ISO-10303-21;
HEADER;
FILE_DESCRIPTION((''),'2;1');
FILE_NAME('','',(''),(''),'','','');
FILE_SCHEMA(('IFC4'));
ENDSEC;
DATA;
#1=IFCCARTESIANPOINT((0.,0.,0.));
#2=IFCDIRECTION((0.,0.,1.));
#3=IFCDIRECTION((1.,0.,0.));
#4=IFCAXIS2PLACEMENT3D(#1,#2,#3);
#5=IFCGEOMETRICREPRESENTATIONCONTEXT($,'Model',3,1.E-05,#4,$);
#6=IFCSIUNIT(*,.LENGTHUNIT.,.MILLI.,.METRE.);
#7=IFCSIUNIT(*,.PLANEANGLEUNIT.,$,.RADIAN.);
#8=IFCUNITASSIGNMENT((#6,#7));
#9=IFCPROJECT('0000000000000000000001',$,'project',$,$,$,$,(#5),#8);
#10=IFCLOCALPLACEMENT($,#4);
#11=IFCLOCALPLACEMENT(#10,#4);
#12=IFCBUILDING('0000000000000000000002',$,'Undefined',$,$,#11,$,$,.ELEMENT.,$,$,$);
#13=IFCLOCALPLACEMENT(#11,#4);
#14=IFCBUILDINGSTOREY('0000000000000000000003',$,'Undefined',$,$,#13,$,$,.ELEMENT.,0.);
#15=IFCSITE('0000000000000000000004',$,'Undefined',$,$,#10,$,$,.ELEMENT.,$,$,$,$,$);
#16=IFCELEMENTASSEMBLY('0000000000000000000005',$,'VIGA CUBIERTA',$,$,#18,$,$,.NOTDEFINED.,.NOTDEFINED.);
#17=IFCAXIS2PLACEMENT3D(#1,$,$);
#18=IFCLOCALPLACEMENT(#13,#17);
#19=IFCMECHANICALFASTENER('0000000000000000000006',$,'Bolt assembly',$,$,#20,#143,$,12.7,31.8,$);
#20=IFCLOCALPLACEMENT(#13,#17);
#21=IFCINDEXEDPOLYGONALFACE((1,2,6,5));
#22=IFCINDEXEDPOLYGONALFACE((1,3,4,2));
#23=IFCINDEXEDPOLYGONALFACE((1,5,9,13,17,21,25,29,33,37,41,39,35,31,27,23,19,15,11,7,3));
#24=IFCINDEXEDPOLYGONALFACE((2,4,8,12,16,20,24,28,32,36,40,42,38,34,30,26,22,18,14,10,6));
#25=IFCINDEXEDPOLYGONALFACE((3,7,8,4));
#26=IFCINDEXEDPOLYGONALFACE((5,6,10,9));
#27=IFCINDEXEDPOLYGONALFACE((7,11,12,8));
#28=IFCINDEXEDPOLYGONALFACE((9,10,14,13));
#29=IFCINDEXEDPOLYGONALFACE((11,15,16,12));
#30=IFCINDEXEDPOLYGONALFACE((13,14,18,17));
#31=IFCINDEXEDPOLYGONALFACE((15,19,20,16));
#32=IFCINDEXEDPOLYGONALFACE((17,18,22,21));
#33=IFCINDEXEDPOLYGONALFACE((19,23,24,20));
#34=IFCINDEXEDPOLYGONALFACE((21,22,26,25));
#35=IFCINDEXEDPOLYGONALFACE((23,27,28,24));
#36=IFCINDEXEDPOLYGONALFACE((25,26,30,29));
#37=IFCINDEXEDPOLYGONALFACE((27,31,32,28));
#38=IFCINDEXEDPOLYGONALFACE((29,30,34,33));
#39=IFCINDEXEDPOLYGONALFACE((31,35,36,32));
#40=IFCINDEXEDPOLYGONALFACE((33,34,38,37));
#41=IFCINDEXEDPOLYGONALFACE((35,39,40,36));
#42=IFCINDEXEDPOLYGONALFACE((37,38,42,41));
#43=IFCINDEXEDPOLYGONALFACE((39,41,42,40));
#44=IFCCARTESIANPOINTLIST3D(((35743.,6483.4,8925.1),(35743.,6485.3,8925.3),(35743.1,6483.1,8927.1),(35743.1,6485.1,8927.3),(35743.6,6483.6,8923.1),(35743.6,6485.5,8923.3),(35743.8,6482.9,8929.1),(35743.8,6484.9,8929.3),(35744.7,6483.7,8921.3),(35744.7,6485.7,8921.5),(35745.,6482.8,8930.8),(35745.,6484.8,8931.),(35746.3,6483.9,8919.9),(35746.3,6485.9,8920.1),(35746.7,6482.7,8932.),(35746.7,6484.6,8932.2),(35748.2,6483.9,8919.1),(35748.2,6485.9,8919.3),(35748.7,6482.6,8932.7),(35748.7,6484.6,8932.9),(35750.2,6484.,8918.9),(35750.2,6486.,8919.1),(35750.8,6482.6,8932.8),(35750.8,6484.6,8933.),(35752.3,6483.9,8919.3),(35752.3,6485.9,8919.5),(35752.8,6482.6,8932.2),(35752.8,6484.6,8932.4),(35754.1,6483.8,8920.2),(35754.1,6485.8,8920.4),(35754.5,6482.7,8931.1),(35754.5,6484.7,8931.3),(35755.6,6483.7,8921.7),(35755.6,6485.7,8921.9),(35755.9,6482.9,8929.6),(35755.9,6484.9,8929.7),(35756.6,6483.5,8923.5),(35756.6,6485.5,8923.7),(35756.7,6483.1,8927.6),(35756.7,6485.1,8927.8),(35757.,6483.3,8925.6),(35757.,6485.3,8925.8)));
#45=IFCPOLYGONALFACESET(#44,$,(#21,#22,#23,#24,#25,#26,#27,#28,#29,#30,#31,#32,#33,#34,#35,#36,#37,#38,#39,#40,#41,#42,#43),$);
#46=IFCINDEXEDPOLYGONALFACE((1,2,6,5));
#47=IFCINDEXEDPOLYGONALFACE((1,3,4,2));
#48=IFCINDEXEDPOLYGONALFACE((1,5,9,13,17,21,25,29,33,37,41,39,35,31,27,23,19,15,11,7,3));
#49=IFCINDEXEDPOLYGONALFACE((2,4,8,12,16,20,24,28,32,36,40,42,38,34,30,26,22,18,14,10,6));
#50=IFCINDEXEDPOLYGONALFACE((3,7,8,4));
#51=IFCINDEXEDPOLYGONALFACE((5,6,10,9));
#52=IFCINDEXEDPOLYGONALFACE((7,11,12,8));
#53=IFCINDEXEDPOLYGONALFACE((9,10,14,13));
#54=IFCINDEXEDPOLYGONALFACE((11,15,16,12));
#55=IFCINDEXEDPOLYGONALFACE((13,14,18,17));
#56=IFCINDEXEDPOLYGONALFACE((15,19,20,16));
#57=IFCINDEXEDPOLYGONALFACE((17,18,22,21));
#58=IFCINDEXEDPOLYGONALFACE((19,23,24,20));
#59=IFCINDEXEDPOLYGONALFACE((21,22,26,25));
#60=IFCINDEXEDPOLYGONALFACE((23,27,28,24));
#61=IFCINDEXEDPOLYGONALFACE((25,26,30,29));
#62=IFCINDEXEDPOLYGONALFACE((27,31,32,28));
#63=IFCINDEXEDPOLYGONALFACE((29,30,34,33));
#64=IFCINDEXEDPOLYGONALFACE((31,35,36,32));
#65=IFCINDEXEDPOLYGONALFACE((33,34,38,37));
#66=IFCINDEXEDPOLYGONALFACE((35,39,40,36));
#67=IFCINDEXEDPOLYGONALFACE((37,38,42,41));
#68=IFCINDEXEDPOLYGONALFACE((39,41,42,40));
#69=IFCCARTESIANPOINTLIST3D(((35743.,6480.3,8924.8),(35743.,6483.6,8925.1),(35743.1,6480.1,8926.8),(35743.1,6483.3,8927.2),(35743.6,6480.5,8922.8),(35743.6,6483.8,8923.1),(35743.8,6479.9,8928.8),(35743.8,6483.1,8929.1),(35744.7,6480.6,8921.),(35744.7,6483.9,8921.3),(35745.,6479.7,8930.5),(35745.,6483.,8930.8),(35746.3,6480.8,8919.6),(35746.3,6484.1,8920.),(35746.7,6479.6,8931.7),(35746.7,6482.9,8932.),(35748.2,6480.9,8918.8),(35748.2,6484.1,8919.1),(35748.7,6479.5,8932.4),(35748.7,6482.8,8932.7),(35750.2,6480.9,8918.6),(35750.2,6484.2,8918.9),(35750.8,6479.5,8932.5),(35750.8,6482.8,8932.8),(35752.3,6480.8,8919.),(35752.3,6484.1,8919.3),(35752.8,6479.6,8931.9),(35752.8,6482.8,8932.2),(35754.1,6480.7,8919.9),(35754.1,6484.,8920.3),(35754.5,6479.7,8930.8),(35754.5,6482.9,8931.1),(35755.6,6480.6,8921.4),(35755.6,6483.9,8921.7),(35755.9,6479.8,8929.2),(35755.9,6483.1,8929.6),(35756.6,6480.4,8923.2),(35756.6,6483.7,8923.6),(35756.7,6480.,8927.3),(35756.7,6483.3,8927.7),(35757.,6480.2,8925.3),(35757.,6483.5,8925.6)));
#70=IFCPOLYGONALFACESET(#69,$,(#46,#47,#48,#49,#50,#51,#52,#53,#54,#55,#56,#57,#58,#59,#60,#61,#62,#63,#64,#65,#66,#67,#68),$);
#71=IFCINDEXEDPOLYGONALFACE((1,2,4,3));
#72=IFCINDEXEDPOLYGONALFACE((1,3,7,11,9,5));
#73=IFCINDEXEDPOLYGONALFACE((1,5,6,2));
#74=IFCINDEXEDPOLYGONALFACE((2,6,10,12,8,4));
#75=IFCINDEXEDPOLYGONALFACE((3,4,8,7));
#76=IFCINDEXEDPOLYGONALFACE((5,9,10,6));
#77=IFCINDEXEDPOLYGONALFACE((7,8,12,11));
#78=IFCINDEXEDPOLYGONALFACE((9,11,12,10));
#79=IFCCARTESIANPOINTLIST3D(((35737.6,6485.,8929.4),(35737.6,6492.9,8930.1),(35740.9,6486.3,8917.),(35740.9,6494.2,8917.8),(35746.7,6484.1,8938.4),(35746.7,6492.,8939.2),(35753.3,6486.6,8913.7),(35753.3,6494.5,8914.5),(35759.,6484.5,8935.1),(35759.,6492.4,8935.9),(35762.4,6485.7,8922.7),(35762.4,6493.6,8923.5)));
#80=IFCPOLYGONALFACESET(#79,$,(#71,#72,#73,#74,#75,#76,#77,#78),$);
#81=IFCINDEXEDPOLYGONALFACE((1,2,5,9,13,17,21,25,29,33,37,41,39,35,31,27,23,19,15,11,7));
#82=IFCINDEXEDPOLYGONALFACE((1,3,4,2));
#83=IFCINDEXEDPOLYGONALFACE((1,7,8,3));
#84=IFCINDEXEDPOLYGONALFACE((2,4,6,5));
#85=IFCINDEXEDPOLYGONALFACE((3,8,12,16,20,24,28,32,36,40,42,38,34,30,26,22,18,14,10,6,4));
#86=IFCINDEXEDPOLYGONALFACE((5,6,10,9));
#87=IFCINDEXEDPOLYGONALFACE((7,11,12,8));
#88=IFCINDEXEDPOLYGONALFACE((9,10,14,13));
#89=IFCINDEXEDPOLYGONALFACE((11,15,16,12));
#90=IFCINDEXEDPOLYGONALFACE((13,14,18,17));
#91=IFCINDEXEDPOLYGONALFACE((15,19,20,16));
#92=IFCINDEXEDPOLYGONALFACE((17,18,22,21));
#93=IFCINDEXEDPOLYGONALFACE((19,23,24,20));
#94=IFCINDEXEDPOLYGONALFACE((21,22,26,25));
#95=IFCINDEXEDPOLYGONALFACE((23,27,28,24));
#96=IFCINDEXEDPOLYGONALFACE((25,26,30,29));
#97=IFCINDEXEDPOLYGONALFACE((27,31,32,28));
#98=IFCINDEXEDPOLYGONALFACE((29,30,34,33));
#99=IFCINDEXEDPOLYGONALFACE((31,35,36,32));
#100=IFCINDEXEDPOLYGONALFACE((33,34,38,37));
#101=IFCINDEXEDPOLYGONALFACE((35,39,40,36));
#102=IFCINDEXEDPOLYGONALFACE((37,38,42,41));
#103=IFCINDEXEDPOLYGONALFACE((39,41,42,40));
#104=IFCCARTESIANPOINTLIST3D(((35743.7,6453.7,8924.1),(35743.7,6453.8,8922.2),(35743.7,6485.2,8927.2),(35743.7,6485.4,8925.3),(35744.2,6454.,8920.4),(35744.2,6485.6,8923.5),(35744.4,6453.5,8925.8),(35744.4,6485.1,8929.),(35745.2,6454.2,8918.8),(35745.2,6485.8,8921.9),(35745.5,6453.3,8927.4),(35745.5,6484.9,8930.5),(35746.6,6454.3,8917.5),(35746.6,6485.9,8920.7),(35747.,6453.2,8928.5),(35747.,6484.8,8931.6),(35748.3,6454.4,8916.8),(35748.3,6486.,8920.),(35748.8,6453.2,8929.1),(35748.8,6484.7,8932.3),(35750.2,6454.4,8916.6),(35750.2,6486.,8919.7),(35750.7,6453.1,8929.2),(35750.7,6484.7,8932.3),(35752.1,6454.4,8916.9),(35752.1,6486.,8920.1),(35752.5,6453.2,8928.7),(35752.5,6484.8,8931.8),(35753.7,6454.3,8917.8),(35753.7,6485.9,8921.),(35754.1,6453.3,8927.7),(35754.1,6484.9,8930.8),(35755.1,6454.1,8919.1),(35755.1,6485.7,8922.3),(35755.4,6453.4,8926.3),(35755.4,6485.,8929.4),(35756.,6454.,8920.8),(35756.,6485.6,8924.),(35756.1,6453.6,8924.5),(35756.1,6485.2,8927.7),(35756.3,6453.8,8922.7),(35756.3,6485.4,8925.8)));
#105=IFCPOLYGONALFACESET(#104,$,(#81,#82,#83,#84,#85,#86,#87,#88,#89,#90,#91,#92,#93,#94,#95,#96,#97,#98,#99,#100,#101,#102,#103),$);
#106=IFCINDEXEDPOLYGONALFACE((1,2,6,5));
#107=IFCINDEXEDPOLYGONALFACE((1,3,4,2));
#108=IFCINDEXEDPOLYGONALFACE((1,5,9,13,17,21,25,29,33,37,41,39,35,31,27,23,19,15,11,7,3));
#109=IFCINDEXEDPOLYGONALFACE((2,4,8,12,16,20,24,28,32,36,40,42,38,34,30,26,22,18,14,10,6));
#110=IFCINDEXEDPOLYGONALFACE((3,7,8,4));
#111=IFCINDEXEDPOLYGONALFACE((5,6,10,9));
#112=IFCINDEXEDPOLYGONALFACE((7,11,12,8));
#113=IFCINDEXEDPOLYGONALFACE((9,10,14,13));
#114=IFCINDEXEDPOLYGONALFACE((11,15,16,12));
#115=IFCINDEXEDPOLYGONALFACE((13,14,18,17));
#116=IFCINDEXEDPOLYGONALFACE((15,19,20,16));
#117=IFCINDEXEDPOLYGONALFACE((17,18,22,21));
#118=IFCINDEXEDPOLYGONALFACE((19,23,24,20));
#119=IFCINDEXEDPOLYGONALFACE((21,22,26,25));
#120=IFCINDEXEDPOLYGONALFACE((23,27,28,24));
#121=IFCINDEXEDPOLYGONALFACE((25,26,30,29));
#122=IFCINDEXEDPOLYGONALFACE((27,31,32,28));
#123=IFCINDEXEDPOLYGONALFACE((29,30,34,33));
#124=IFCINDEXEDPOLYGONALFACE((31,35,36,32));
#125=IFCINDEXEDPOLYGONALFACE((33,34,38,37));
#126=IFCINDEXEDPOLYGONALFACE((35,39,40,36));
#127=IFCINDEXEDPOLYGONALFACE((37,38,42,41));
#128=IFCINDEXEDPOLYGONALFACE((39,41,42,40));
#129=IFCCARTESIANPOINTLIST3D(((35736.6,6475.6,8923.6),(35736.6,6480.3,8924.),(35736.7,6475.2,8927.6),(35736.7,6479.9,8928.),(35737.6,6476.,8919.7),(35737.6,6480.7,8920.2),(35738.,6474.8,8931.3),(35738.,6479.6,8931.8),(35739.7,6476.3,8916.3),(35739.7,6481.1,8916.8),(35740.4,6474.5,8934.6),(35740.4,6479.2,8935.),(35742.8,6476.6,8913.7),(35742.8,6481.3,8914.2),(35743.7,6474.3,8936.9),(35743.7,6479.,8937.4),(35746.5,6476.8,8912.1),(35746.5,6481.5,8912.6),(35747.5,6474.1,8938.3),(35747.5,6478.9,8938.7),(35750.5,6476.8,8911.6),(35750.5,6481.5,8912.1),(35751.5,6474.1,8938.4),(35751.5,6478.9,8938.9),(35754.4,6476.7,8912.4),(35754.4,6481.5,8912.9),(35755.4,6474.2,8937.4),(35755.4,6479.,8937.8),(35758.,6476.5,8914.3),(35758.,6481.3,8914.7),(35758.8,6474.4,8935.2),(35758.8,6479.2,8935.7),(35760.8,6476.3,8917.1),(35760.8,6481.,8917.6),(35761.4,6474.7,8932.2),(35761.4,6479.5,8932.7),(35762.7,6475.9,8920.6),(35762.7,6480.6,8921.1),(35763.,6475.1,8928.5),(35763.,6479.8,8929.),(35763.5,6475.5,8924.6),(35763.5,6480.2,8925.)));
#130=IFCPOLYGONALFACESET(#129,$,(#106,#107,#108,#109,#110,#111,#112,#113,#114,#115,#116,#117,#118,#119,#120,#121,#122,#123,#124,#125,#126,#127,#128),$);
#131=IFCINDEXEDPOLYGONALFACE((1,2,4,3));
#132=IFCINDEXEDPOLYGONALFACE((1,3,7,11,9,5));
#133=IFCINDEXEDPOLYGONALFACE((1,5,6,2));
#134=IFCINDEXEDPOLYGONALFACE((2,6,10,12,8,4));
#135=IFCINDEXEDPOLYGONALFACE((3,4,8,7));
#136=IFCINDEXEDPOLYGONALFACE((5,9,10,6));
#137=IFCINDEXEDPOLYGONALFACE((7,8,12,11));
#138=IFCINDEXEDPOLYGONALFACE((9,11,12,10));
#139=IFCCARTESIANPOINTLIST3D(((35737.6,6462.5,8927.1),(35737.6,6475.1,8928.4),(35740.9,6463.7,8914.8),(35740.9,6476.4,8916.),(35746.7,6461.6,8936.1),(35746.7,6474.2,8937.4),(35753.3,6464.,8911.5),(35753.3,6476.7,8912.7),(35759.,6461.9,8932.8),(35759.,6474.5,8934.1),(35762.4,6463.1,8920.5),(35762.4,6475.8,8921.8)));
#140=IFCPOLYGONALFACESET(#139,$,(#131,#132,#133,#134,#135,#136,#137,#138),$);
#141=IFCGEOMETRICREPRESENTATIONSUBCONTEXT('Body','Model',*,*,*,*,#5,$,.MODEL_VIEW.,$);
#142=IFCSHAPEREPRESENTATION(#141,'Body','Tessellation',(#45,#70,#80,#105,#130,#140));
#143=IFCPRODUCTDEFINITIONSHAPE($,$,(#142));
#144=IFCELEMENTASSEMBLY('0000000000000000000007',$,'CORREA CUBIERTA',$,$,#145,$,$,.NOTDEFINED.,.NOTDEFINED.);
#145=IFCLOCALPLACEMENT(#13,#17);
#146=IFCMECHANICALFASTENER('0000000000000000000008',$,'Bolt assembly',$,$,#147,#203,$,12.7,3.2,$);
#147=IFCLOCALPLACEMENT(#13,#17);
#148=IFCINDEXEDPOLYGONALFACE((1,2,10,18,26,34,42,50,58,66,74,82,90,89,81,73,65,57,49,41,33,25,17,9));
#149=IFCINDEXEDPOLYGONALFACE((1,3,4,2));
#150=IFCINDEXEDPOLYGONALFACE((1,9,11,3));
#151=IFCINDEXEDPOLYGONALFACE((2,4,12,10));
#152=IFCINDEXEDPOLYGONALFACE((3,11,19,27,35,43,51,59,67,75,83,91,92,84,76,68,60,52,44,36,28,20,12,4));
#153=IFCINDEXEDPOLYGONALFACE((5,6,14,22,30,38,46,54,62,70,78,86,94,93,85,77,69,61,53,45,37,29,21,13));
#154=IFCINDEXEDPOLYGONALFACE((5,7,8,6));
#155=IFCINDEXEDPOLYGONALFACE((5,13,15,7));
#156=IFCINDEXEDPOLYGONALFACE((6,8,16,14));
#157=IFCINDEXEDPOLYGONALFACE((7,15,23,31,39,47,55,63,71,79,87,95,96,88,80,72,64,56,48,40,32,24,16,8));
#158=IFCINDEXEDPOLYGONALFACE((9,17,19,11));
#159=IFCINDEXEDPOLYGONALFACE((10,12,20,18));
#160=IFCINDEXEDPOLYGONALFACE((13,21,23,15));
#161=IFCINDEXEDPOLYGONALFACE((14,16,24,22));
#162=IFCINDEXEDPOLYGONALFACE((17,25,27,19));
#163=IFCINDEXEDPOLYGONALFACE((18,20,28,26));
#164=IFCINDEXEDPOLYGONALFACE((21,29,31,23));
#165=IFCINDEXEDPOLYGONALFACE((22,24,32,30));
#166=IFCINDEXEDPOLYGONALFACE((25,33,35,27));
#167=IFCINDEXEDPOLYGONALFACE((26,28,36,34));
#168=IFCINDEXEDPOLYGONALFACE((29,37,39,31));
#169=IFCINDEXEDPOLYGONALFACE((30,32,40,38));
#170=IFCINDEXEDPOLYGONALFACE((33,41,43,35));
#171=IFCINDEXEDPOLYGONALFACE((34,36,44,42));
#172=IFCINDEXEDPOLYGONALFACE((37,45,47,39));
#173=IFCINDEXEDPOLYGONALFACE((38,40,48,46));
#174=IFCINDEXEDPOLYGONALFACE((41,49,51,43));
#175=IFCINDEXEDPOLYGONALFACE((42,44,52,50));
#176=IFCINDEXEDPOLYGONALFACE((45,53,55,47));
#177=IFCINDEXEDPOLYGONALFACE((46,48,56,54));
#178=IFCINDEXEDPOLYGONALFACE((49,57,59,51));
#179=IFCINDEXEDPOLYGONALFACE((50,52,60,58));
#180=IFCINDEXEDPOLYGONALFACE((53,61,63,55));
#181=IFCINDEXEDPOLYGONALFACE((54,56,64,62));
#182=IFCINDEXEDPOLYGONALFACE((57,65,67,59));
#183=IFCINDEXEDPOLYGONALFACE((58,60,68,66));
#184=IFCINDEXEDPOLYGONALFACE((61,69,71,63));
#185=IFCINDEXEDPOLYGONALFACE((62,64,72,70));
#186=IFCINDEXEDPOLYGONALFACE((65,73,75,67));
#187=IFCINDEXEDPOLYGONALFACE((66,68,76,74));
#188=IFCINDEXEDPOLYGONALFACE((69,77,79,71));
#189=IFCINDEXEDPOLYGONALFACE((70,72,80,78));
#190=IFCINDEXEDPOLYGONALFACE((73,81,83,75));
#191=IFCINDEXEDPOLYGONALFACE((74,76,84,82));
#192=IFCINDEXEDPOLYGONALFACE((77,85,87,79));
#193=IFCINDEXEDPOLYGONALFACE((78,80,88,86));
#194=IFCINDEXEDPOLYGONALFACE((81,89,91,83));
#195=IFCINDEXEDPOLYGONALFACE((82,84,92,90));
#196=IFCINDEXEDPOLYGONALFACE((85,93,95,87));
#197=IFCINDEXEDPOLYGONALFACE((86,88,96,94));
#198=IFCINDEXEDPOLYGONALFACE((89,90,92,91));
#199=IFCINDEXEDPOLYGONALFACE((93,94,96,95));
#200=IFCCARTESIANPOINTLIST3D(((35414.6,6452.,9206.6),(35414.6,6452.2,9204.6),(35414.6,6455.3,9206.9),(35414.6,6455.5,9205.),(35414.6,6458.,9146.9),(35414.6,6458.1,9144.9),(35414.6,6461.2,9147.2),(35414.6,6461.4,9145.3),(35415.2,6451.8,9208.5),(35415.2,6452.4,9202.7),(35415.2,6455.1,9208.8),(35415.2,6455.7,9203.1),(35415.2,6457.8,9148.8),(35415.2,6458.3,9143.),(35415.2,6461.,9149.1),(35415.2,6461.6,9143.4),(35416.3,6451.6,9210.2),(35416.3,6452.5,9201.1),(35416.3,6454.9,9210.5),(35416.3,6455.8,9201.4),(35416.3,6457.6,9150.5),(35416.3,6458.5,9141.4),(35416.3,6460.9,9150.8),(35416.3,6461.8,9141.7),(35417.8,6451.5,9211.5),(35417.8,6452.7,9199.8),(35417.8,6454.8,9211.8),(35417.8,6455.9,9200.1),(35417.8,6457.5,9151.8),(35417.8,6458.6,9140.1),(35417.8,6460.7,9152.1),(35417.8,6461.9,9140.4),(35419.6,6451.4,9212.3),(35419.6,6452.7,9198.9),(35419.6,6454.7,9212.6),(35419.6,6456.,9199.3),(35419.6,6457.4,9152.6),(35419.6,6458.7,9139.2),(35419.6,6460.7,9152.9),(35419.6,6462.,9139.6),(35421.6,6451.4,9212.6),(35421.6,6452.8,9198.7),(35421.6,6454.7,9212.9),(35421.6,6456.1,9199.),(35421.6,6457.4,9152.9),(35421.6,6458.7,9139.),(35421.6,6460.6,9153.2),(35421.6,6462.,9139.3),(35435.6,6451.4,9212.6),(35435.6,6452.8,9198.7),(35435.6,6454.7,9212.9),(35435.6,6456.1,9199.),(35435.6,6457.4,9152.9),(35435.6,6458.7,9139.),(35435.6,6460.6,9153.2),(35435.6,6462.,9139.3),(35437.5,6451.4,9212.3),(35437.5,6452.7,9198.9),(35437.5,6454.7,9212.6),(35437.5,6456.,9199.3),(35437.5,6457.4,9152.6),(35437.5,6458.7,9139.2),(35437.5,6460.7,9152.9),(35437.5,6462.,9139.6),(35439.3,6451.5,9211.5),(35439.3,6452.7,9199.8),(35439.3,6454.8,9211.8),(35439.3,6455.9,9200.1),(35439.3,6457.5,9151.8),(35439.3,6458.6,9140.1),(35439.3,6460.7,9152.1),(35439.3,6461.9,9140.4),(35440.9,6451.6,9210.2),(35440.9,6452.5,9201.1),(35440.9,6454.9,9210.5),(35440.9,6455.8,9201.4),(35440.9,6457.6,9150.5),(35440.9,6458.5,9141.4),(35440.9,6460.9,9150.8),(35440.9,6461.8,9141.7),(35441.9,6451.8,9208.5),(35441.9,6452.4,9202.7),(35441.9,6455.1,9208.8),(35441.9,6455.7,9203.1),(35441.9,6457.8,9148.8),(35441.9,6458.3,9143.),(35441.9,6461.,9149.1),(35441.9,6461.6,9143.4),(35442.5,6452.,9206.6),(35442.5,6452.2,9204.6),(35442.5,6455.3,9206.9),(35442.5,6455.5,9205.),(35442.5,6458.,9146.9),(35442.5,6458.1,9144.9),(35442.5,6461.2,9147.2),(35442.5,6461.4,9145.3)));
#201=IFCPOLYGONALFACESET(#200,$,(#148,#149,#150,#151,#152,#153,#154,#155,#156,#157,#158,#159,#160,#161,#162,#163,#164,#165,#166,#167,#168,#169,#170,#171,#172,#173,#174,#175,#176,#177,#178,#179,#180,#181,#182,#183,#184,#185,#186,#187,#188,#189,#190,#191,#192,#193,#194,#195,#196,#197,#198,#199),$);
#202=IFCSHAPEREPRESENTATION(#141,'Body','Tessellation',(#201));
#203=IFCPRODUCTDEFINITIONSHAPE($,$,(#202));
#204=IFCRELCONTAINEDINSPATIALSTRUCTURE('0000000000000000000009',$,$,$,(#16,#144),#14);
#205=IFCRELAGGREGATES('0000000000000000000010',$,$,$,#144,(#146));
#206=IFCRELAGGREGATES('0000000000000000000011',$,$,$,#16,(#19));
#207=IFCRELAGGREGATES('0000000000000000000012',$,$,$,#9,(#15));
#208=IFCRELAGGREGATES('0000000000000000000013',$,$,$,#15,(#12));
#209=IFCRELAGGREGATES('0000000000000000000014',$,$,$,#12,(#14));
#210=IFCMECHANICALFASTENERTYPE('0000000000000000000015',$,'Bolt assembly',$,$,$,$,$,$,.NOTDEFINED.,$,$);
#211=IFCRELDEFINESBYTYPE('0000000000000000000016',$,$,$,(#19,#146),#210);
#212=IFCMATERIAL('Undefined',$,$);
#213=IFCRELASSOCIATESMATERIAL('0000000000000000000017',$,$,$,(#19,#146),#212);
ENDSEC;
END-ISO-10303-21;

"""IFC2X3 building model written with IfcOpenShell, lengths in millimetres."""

from ifc_helpers import new_model, si_unit, frame, frame_2d, origin_with_axes, origin_2d_with_axis, place, context, subcontext, project, spatial, polyline, circle_curve, parameter, trimmed, segment, composite_curve, circle, outline, extrude, source, transform, mapped, material, type_object, element, aggregate, save


model = new_model("IFC2X3")

# Units and contexts
model_context = context("Model", 3, precision=1e-05, world=origin_with_axes())
body_context = subcontext(model_context, "Body", "Model", "MODEL_VIEW")
ifc_project = project(units=[si_unit("LENGTHUNIT", "METRE", prefix="MILLI"), si_unit("PLANEANGLEUNIT", "RADIAN")], contexts=[model_context])

# Site, building, storey
site_placement = place(None, origin_with_axes())
site = spatial("IfcSite", under=ifc_project, at=site_placement, Name="Undefined", CompositionType="ELEMENT")
building_placement = place(site_placement, origin_with_axes())
building = spatial("IfcBuilding", under=site, at=building_placement, Name="Undefined", CompositionType="ELEMENT")
storey_placement = place(building_placement, origin_with_axes())
storey = spatial("IfcBuildingStorey", under=building, at=storey_placement, Name="Undefined", CompositionType="ELEMENT", Elevation=0.0)

# Element assembly
assembly_1_placement = place(storey_placement, origin_with_axes())
assembly_1 = element("IfcElementAssembly", 1, at=assembly_1_placement, inside=storey, Name="VIGA CUBIERTA", AssemblyPlace="NOTDEFINED", PredefinedType="NOTDEFINED")

# Shared definitions
ifc_material_1 = material(Name="Undefined")
mechanical_fastener_type = type_object("IfcMechanicalFastenerType", Name="Bolt assembly")

# Mechanical fastener
shared_shape_1 = source(origin_with_axes(), body_context, "Body", "SweptSolid", [
    extrude(circle(Radius=7.0, at=origin_2d_with_axis()), frame((0.0, -1.9, 0.0), z_axis=(0.0, 1.0, 0.0), x_axis=(1.0, 0.0, 0.0)), (0.0, 0.0, 1.0), 2.0),
    extrude(circle(Radius=7.0, at=origin_2d_with_axis()), frame((0.0, -0.1, 0.0), z_axis=(0.0, 1.0, 0.0), x_axis=(1.0, 0.0, 0.0)), (0.0, 0.0, 1.0), 3.3),
    extrude(outline(polyline([(11.1, -6.4), (11.1, 6.4), (0.0, 12.8), (-11.1, 6.4), (-11.1, -6.4), (0.0, -12.8), (11.1, -6.4)])), frame((0.0, -9.9, 0.0), z_axis=(0.0, 1.0, 0.0), x_axis=(1.0, 0.0, 0.0)), (0.0, 0.0, 1.0), 7.9),
    extrude(circle(Radius=6.3, at=origin_2d_with_axis()), frame((0.0, -2.0, 0.0), z_axis=(0.0, 1.0, 0.0), x_axis=(1.0, 0.0, 0.0)), (0.0, 0.0, 1.0), 31.8),
    extrude(circle(Radius=13.5, at=origin_2d_with_axis()), frame((0.0, 3.2, 0.0), z_axis=(0.0, 1.0, 0.0), x_axis=(1.0, 0.0, 0.0)), (0.0, 0.0, 1.0), 4.8),
    extrude(outline(polyline([(11.1, -6.4), (11.1, 6.4), (0.0, 12.8), (-11.1, 6.4), (-11.1, -6.4), (0.0, -12.8), (11.1, -6.4)])), frame((0.0, 8.0, 0.0), z_axis=(0.0, 1.0, 0.0), x_axis=(1.0, 0.0, 0.0)), (0.0, 0.0, 1.0), 12.7),
])
mechanical_fastener_1_placement = place(assembly_1_placement, frame((35750.0, 6483.4, 8925.9), z_axis=(0.707107, -0.07036, 0.703598), x_axis=(-0.707107, -0.070359, 0.703598)))
mechanical_fastener_1 = element("IfcMechanicalFastener", 2, at=mechanical_fastener_1_placement, type_object=mechanical_fastener_type, material=ifc_material_1, Name="Bolt assembly", NominalDiameter=12.7, NominalLength=31.8, context=body_context, shape_type="MappedRepresentation", body=[
    mapped(shared_shape_1, transform((0.0, 0.0, 0.0))),
])

# Element assembly, mechanical fastener
assembly_2_placement = place(storey_placement, origin_with_axes())
assembly_2 = element("IfcElementAssembly", 3, at=assembly_2_placement, inside=storey, Name="CORREA CUBIERTA", AssemblyPlace="NOTDEFINED", PredefinedType="NOTDEFINED")
shared_shape_2 = source(origin_with_axes(), body_context, "Body", "SweptSolid", [
    extrude(outline(composite_curve([segment(polyline([(7.0, 7.0), (7.0, -7.0)]), True, "CONTINUOUS"), segment(trimmed(circle_curve(frame_2d((0.0, -7.0), x_axis=(1.0, 0.0)), 7.0), [parameter(0.0)], [parameter(3.141593)], False, "PARAMETER"), True, "CONTINUOUS"), segment(polyline([(-7.0, -7.0), (-7.0, 7.0)]), True, "CONTINUOUS"), segment(trimmed(circle_curve(frame_2d((0.0, 7.0), x_axis=(-1.0, 0.0)), 7.0), [parameter(0.0)], [parameter(3.141593)], False, "PARAMETER"), True, "DISCONTINUOUS")], self_intersect=False)), frame((0.0, 3.2, 0.0), z_axis=(0.0, 1.0, 0.0), x_axis=(1.0, 0.0, 0.0)), (0.0, 0.0, 1.0), 3.3),
])
mechanical_fastener_2_placement = place(assembly_2_placement, frame((35428.6, 6458.6, 9206.3), z_axis=(-1.0, 0.0, 0.0), x_axis=(0.0, 0.099502, -0.995037)))
mechanical_fastener_2 = element("IfcMechanicalFastener", 4, at=mechanical_fastener_2_placement, type_object=mechanical_fastener_type, material=ifc_material_1, Name="Bolt assembly", NominalDiameter=12.7, NominalLength=3.2, context=body_context, shape_type="MappedRepresentation", body=[
    mapped(shared_shape_2, transform((0.0, 0.0, 0.0))),
    mapped(shared_shape_2, transform((60.0, 0.0, 0.0))),
])

aggregate(assembly_2, [mechanical_fastener_2])

aggregate(assembly_1, [mechanical_fastener_1])

save(model, "model.ifc")
